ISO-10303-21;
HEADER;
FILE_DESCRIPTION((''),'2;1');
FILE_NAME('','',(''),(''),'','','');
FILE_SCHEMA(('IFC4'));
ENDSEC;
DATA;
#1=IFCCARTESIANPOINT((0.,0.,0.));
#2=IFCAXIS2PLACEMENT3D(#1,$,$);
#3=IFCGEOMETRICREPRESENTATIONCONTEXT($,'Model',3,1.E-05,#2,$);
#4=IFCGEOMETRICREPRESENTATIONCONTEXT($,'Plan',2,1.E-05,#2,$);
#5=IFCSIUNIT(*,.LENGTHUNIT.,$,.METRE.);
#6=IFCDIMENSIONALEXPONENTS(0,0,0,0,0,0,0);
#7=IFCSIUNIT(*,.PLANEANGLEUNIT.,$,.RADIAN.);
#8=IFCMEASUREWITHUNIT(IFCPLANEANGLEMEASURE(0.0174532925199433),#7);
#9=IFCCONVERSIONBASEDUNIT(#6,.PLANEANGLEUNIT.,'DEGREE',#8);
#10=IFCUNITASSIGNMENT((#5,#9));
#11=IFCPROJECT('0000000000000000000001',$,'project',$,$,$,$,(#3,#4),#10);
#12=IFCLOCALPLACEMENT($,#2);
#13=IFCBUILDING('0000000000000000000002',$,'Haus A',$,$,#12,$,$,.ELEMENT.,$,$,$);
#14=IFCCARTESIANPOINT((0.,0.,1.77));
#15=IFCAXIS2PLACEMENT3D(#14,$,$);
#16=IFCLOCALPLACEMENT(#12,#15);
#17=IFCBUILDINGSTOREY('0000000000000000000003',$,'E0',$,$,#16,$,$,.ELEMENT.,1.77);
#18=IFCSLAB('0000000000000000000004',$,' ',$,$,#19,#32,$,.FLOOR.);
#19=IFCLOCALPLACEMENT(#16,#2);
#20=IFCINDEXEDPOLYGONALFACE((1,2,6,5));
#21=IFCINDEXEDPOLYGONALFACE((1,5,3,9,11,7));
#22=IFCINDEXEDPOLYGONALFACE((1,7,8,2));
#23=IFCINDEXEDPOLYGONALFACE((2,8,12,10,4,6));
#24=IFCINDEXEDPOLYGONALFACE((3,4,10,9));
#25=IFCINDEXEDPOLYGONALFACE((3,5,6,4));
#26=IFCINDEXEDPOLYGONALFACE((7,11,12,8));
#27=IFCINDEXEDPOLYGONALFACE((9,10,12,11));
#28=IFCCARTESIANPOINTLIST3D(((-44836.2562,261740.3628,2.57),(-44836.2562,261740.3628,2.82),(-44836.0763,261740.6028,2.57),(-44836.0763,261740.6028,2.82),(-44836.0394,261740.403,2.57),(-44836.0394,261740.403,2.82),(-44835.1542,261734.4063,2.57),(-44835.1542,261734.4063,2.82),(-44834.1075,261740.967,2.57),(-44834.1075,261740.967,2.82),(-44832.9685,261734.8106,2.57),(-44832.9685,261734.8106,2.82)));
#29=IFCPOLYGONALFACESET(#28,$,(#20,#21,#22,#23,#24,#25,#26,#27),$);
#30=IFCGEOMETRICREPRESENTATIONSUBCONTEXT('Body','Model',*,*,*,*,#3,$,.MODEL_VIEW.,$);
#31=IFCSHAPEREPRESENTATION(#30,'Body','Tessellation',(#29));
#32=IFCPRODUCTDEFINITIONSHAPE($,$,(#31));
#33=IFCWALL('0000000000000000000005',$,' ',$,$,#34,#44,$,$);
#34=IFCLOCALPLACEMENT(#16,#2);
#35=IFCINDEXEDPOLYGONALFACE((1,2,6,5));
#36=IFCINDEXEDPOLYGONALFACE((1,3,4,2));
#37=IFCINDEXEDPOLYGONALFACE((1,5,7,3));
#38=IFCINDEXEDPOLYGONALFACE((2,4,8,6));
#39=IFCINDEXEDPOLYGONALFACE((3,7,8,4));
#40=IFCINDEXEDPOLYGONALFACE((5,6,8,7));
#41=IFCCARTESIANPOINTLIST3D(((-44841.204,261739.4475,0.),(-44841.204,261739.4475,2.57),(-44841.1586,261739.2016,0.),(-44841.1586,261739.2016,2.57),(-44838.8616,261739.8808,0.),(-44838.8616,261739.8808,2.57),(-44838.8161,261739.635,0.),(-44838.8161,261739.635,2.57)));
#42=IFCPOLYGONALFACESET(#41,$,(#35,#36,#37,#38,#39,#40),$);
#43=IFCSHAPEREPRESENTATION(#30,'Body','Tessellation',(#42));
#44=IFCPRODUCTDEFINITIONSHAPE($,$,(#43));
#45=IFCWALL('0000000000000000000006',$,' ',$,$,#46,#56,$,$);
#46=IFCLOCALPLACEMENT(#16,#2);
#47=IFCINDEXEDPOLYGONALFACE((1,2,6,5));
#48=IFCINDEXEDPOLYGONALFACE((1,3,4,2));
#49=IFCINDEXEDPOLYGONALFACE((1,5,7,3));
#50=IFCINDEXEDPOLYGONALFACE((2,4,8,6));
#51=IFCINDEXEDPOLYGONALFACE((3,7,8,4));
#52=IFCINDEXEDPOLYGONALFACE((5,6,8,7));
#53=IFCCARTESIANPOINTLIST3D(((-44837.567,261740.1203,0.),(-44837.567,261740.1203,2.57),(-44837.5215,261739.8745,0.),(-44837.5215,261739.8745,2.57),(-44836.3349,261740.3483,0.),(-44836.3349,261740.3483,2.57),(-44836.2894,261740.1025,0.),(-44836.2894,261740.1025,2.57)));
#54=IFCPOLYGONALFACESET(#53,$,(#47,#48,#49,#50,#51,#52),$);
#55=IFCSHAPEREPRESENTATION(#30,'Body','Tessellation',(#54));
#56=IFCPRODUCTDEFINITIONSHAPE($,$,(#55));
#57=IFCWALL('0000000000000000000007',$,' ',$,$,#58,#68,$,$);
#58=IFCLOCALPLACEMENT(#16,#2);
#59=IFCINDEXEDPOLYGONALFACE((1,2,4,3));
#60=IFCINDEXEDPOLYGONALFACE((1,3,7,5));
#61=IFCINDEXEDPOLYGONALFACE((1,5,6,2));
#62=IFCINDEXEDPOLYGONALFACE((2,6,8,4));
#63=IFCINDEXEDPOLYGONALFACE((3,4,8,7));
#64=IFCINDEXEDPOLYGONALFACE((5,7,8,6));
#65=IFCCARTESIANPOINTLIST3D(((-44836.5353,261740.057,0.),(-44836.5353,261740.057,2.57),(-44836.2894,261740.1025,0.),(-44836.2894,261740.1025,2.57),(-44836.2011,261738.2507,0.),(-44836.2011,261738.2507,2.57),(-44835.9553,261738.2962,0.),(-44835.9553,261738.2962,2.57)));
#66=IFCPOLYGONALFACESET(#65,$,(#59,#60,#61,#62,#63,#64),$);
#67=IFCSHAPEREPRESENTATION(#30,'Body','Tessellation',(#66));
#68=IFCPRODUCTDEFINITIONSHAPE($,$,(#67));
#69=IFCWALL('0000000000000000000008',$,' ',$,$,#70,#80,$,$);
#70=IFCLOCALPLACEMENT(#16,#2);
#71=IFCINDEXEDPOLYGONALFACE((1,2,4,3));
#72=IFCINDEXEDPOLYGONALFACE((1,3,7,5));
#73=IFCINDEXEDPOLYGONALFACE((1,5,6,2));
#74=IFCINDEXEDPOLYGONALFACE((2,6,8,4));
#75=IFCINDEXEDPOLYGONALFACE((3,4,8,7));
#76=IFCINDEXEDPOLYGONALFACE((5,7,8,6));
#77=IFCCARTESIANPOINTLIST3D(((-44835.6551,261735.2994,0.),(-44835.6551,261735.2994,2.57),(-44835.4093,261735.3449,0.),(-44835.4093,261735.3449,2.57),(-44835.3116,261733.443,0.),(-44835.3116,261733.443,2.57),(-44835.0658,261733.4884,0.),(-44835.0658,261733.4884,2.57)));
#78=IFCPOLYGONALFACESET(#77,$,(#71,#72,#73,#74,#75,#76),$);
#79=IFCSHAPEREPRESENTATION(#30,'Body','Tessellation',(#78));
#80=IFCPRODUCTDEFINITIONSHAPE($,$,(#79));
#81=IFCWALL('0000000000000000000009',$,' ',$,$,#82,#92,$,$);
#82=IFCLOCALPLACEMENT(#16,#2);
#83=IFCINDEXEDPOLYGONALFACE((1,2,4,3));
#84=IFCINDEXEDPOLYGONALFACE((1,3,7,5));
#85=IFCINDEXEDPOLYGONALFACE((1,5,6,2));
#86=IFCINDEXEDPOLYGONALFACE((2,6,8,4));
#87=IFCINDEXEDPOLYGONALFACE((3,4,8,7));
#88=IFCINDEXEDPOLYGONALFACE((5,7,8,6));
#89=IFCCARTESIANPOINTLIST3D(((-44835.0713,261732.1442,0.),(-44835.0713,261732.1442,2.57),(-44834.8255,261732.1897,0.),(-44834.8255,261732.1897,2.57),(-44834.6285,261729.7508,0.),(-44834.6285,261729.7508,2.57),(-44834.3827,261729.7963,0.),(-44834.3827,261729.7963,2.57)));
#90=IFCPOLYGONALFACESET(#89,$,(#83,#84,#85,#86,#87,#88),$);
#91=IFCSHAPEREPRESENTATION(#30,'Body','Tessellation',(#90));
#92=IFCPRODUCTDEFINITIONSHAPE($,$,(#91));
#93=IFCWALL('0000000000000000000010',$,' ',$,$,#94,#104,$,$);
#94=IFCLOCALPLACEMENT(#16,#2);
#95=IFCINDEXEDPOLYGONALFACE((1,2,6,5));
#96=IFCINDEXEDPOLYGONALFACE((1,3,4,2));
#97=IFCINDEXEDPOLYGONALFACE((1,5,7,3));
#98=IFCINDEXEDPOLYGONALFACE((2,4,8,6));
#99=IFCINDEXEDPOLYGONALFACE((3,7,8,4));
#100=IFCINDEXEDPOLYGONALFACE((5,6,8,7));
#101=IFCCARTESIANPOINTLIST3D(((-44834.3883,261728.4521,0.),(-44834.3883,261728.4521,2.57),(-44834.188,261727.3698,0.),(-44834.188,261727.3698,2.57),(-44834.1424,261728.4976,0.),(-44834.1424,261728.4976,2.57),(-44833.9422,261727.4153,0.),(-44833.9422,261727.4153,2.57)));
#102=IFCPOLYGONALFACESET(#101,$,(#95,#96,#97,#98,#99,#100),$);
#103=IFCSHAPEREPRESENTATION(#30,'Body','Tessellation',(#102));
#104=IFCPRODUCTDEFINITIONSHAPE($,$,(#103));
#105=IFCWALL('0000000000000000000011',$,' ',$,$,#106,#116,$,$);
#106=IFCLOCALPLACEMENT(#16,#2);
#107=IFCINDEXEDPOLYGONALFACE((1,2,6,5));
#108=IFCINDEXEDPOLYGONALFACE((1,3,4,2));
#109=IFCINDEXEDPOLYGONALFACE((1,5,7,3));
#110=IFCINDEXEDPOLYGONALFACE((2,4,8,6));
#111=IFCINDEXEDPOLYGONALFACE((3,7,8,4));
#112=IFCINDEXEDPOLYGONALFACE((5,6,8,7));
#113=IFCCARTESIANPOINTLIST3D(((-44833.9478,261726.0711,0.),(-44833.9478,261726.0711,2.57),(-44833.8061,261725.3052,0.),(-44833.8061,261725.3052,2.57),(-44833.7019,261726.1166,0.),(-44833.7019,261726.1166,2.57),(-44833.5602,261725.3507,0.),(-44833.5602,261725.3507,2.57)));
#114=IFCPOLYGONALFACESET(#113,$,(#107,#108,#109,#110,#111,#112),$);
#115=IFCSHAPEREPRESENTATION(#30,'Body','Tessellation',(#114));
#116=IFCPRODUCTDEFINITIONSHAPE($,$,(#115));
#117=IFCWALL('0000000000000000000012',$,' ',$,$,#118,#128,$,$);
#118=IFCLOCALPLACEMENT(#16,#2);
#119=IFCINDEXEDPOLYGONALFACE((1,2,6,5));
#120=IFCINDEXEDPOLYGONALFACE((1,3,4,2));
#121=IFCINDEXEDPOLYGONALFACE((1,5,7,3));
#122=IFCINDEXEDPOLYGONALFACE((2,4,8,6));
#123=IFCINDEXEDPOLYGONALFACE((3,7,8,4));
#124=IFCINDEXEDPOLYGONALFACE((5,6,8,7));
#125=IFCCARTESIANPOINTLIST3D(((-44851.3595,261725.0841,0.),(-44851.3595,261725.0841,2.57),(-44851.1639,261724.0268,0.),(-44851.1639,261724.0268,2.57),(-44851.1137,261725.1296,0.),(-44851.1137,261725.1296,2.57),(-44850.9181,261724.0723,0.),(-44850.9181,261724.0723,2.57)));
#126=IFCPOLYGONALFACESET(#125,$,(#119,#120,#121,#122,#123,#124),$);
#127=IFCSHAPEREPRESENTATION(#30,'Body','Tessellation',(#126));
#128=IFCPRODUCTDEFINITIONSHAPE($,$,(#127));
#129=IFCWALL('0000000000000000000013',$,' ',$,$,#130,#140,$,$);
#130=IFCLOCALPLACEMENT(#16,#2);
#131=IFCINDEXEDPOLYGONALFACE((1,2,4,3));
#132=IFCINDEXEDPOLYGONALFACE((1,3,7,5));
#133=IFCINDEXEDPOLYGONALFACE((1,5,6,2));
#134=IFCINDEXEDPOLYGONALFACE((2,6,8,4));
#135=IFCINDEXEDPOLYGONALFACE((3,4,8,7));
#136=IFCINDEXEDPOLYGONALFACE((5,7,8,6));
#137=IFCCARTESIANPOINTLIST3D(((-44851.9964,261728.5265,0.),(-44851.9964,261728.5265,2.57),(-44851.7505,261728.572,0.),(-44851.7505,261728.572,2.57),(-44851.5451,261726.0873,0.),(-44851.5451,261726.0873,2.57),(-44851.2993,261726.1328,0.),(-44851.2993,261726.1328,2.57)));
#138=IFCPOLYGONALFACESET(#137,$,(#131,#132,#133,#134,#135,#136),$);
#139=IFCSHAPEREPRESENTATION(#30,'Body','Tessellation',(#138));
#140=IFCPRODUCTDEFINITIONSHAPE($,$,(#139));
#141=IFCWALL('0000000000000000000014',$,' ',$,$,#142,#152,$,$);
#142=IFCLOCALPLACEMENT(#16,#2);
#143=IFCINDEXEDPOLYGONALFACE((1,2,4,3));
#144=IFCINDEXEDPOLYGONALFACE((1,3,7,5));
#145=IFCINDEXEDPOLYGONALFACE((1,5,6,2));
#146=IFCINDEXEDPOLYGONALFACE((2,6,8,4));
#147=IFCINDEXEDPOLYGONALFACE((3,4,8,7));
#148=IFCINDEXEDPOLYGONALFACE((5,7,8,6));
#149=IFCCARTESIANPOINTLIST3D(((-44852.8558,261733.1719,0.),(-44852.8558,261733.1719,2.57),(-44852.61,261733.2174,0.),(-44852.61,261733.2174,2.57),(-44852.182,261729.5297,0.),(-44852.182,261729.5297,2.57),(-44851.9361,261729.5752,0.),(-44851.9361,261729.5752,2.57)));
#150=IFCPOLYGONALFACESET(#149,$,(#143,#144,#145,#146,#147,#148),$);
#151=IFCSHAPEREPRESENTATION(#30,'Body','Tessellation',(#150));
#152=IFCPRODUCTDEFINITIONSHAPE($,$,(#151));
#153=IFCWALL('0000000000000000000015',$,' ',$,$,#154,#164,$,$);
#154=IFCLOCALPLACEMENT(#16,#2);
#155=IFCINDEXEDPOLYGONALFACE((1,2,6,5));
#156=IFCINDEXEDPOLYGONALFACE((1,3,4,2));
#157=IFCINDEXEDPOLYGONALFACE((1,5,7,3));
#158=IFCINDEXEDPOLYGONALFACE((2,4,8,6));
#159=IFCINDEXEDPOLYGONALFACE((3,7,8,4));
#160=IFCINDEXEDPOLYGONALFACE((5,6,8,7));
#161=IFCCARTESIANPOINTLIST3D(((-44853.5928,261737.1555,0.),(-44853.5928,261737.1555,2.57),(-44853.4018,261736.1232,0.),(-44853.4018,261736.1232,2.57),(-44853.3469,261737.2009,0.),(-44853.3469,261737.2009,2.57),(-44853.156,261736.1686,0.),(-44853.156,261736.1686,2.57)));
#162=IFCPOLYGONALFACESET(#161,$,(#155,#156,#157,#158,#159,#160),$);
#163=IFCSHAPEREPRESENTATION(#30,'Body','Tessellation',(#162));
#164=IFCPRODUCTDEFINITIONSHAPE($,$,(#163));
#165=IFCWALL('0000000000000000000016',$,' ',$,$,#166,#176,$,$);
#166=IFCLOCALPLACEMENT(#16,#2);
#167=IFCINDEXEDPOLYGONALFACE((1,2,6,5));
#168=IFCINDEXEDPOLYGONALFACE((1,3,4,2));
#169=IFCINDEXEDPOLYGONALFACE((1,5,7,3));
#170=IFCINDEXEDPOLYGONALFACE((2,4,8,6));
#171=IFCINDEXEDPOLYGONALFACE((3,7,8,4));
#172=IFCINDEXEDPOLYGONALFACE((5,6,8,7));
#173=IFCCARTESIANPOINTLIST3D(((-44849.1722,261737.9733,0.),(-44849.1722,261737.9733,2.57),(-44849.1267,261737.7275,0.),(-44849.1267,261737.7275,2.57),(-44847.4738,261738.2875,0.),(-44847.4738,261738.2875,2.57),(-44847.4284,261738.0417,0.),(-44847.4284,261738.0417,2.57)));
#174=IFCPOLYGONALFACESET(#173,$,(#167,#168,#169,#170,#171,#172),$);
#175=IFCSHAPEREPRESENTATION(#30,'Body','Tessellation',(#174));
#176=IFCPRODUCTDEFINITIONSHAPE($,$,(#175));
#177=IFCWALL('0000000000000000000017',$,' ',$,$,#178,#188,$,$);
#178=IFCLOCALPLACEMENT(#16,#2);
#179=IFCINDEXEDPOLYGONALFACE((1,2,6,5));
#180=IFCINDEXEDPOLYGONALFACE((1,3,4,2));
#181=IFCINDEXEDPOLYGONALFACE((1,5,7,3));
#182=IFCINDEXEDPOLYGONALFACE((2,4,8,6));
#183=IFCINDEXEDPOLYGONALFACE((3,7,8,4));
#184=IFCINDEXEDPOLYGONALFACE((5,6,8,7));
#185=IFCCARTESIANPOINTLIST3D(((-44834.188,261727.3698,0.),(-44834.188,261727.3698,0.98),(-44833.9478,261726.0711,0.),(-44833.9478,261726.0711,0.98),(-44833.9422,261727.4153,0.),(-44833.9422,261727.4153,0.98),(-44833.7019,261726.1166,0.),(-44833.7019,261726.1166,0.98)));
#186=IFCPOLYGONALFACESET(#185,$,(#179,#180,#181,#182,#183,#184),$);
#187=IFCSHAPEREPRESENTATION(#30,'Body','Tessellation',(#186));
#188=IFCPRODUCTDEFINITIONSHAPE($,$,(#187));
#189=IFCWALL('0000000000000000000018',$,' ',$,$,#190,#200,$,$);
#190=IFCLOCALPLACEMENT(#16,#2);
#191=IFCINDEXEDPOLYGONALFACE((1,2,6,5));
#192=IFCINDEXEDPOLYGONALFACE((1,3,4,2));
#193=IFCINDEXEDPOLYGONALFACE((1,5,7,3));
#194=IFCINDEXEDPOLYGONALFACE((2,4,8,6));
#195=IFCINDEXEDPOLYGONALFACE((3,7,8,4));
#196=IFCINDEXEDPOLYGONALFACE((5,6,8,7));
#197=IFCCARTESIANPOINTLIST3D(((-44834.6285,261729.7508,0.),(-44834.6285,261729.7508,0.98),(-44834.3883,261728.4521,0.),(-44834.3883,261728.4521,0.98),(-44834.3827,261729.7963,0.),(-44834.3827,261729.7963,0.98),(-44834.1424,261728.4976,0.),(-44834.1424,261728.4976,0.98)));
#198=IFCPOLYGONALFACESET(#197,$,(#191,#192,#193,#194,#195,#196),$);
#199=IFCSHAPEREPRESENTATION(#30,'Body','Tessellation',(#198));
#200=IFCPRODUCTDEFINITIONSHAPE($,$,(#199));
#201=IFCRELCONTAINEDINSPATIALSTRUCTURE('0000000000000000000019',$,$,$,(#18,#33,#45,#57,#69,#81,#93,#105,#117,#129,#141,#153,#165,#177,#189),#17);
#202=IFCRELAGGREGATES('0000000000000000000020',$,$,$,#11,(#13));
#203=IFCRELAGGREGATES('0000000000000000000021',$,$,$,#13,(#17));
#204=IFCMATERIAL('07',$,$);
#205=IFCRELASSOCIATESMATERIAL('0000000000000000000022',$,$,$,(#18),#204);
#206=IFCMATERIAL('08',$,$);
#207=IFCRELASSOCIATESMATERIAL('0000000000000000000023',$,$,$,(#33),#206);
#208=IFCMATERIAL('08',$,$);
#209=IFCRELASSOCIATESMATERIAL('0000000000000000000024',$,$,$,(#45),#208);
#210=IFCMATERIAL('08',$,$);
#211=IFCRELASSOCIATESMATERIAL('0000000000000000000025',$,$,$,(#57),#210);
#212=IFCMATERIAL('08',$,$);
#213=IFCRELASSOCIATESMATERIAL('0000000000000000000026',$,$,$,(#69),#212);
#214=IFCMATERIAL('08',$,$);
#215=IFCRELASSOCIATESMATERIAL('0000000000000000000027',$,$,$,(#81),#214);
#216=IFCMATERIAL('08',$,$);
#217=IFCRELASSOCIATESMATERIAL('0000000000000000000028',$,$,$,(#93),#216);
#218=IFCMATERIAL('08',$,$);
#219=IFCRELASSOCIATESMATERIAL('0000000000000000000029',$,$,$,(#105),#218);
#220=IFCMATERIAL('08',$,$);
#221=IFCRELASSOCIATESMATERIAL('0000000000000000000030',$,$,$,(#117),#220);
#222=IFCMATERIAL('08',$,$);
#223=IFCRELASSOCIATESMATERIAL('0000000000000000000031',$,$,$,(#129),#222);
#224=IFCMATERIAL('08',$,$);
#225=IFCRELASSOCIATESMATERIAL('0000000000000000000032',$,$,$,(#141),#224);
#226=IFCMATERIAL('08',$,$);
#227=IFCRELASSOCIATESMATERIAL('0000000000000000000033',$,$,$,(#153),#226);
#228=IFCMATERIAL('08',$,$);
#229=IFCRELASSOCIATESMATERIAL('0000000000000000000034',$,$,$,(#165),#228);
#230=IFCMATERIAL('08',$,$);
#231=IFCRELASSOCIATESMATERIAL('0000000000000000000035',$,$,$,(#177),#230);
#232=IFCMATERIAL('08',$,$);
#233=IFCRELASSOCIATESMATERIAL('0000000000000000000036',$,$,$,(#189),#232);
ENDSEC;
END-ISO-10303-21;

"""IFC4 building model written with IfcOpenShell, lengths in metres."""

from ifc_helpers import new_model, entity, si_unit, converted_unit, frame, frame_2d, origin, origin_with_axes, place, context, subcontext, project, spatial, polyline, rectangle, outline, extrude, material, element, save


model = new_model("IFC4")

# Units and contexts
model_context = context("Model", 3, precision=1e-05, world=origin())
plan_context = context("Plan", 2, precision=1e-05, world=origin())
body_context = subcontext(model_context, "Body", "Model", "MODEL_VIEW")
ifc_project = project(units=[si_unit("LENGTHUNIT", "METRE"), converted_unit("PLANEANGLEUNIT", "DEGREE", entity("IfcPlaneAngleMeasure", 0.0174532925199433), si_unit("PLANEANGLEUNIT", "RADIAN"), dimensions=[0, 0, 0, 0, 0, 0, 0])], contexts=[model_context, plan_context])

# Building, storey
building_placement = place(None, origin())
building = spatial("IfcBuilding", under=ifc_project, at=building_placement, Name="Haus A", CompositionType="ELEMENT")
storey_placement = place(building_placement, frame((0.0, 0.0, 1.77)))
storey = spatial("IfcBuildingStorey", under=building, at=storey_placement, Name="E0", CompositionType="ELEMENT", Elevation=1.77)

# Slab
ifc_material_1 = material(Name="07")
slab_placement = place(storey_placement, frame((-44836.2562, 261734.4063, 2.57)))
element("IfcSlab", 1, at=slab_placement, inside=storey, material=ifc_material_1, Name=" ", PredefinedType="FLOOR", context=body_context, shape_type="SweptSolid", body=[
    extrude(outline(polyline([(1.102, 0.0), (3.2878, 0.4044), (2.1488, 6.5608), (0.1799, 6.1965), (0.2169, 5.9967), (0.0, 5.9566), (1.102, 0.0)])), origin_with_axes(), (0.0, 0.0, 1.0), 0.25),
])

# Walls
ifc_material_2 = material(Name="08")
wall_1_placement = place(storey_placement, frame((-44838.8616, 261739.8808, 0.0), z_axis=(0.0, 0.0, 1.0), x_axis=(-0.983313, -0.18192, 0.0)))
element("IfcWall", 2, at=wall_1_placement, inside=storey, material=ifc_material_2, Name=" ", context=body_context, shape_type="SweptSolid", body=[
    extrude(rectangle(XDim=2.3822, YDim=0.25, at=frame_2d((1.1911, 0.125), x_axis=(1.0, 0.0))), origin_with_axes(), (0.0, 0.0, 1.0), 2.57),
])
ifc_material_3 = material(Name="08")
wall_2_placement = place(storey_placement, frame((-44836.3349, 261740.3483, 0.0), z_axis=(0.0, 0.0, 1.0), x_axis=(-0.983313, -0.18192, 0.0)))
element("IfcWall", 3, at=wall_2_placement, inside=storey, material=ifc_material_3, Name=" ", context=body_context, shape_type="SweptSolid", body=[
    extrude(rectangle(XDim=1.253, YDim=0.25, at=frame_2d((0.6265, 0.125), x_axis=(1.0, 0.0))), origin_with_axes(), (0.0, 0.0, 1.0), 2.57),
])
ifc_material_4 = material(Name="08")
wall_3_placement = place(storey_placement, frame((-44835.9553, 261738.2962, 0.0), z_axis=(0.0, 0.0, 1.0), x_axis=(-0.18192, 0.983313, 0.0)))
element("IfcWall", 4, at=wall_3_placement, inside=storey, material=ifc_material_4, Name=" ", context=body_context, shape_type="SweptSolid", body=[
    extrude(rectangle(XDim=1.837, YDim=0.25, at=frame_2d((0.9185, 0.125), x_axis=(1.0, 0.0))), origin_with_axes(), (0.0, 0.0, 1.0), 2.57),
])
ifc_material_5 = material(Name="08")
wall_4_placement = place(storey_placement, frame((-44835.0658, 261733.4884, 0.0), z_axis=(0.0, 0.0, 1.0), x_axis=(-0.18192, 0.983313, 0.0)))
element("IfcWall", 5, at=wall_4_placement, inside=storey, material=ifc_material_5, Name=" ", context=body_context, shape_type="SweptSolid", body=[
    extrude(rectangle(XDim=1.888, YDim=0.25, at=frame_2d((0.944, 0.125), x_axis=(1.0, 0.0))), origin_with_axes(), (0.0, 0.0, 1.0), 2.57),
])
ifc_material_6 = material(Name="08")
wall_5_placement = place(storey_placement, frame((-44834.3827, 261729.7963, 0.0), z_axis=(0.0, 0.0, 1.0), x_axis=(-0.18192, 0.983313, 0.0)))
element("IfcWall", 6, at=wall_5_placement, inside=storey, material=ifc_material_6, Name=" ", context=body_context, shape_type="SweptSolid", body=[
    extrude(rectangle(XDim=2.4341, YDim=0.25, at=frame_2d((1.217, 0.125), x_axis=(1.0, 0.0))), origin_with_axes(), (0.0, 0.0, 1.0), 2.57),
])
ifc_material_7 = material(Name="08")
wall_6_placement = place(storey_placement, frame((-44833.9422, 261727.4153, 0.0), z_axis=(0.0, 0.0, 1.0), x_axis=(-0.18192, 0.983313, 0.0)))
element("IfcWall", 7, at=wall_6_placement, inside=storey, material=ifc_material_7, Name=" ", context=body_context, shape_type="SweptSolid", body=[
    extrude(rectangle(XDim=1.1006, YDim=0.25, at=frame_2d((0.5503, 0.125), x_axis=(1.0, 0.0))), origin_with_axes(), (0.0, 0.0, 1.0), 2.57),
])
ifc_material_8 = material(Name="08")
wall_7_placement = place(storey_placement, frame((-44833.5602, 261725.3507, 0.0), z_axis=(0.0, 0.0, 1.0), x_axis=(-0.18192, 0.983313, 0.0)))
element("IfcWall", 8, at=wall_7_placement, inside=storey, material=ifc_material_8, Name=" ", context=body_context, shape_type="SweptSolid", body=[
    extrude(rectangle(XDim=0.7789, YDim=0.25, at=frame_2d((0.3895, 0.125), x_axis=(1.0, 0.0))), origin_with_axes(), (0.0, 0.0, 1.0), 2.57),
])
ifc_material_9 = material(Name="08")
wall_8_placement = place(storey_placement, frame((-44851.3595, 261725.0841, 0.0), z_axis=(0.0, 0.0, 1.0), x_axis=(0.18192, -0.983313, 0.0)))
element("IfcWall", 9, at=wall_8_placement, inside=storey, material=ifc_material_9, Name=" ", context=body_context, shape_type="SweptSolid", body=[
    extrude(rectangle(XDim=1.0752, YDim=0.25, at=frame_2d((0.5376, 0.125), x_axis=(1.0, 0.0))), origin_with_axes(), (0.0, 0.0, 1.0), 2.57),
])
ifc_material_10 = material(Name="08")
wall_9_placement = place(storey_placement, frame((-44851.9964, 261728.5265, 0.0), z_axis=(0.0, 0.0, 1.0), x_axis=(0.18192, -0.983313, 0.0)))
element("IfcWall", 10, at=wall_9_placement, inside=storey, material=ifc_material_10, Name=" ", context=body_context, shape_type="SweptSolid", body=[
    extrude(rectangle(XDim=2.4806, YDim=0.25, at=frame_2d((1.2403, 0.125), x_axis=(1.0, 0.0))), origin_with_axes(), (0.0, 0.0, 1.0), 2.57),
])
ifc_material_11 = material(Name="08")
wall_10_placement = place(storey_placement, frame((-44852.8558, 261733.1719, 0.0), z_axis=(0.0, 0.0, 1.0), x_axis=(0.18192, -0.983313, 0.0)))
element("IfcWall", 11, at=wall_10_placement, inside=storey, material=ifc_material_11, Name=" ", context=body_context, shape_type="SweptSolid", body=[
    extrude(rectangle(XDim=3.704, YDim=0.25, at=frame_2d((1.852, 0.125), x_axis=(1.0, 0.0))), origin_with_axes(), (0.0, 0.0, 1.0), 2.57),
])
ifc_material_12 = material(Name="08")
wall_11_placement = place(storey_placement, frame((-44853.5928, 261737.1555, 0.0), z_axis=(0.0, 0.0, 1.0), x_axis=(0.18192, -0.983313, 0.0)))
element("IfcWall", 12, at=wall_11_placement, inside=storey, material=ifc_material_12, Name=" ", context=body_context, shape_type="SweptSolid", body=[
    extrude(rectangle(XDim=1.0498, YDim=0.25, at=frame_2d((0.5249, 0.125), x_axis=(1.0, 0.0))), origin_with_axes(), (0.0, 0.0, 1.0), 2.57),
])
ifc_material_13 = material(Name="08")
wall_12_placement = place(storey_placement, frame((-44847.4738, 261738.2875, 0.0), z_axis=(0.0, 0.0, 1.0), x_axis=(-0.983313, -0.18192, 0.0)))
element("IfcWall", 13, at=wall_12_placement, inside=storey, material=ifc_material_13, Name=" ", context=body_context, shape_type="SweptSolid", body=[
    extrude(rectangle(XDim=1.7271, YDim=0.25, at=frame_2d((0.8636, 0.125), x_axis=(1.0, 0.0))), origin_with_axes(), (0.0, 0.0, 1.0), 2.57),
])
ifc_material_14 = material(Name="08")
wall_13_placement = place(storey_placement, frame((-44833.7019, 261726.1166, 0.0), z_axis=(0.0, 0.0, 1.0), x_axis=(-0.18192, 0.983313, 0.0)))
element("IfcWall", 14, at=wall_13_placement, inside=storey, material=ifc_material_14, Name=" ", context=body_context, shape_type="SweptSolid", body=[
    extrude(rectangle(XDim=1.3207, YDim=0.25, at=frame_2d((0.6604, 0.125), x_axis=(1.0, 0.0))), origin_with_axes(), (0.0, 0.0, 1.0), 0.98),
])
ifc_material_15 = material(Name="08")
wall_14_placement = place(storey_placement, frame((-44834.1424, 261728.4976, 0.0), z_axis=(0.0, 0.0, 1.0), x_axis=(-0.18192, 0.983313, 0.0)))
element("IfcWall", 15, at=wall_14_placement, inside=storey, material=ifc_material_15, Name=" ", context=body_context, shape_type="SweptSolid", body=[
    extrude(rectangle(XDim=1.3207, YDim=0.25, at=frame_2d((0.6604, 0.125), x_axis=(1.0, 0.0))), origin_with_axes(), (0.0, 0.0, 1.0), 0.98),
])

save(model, "model.ifc")
